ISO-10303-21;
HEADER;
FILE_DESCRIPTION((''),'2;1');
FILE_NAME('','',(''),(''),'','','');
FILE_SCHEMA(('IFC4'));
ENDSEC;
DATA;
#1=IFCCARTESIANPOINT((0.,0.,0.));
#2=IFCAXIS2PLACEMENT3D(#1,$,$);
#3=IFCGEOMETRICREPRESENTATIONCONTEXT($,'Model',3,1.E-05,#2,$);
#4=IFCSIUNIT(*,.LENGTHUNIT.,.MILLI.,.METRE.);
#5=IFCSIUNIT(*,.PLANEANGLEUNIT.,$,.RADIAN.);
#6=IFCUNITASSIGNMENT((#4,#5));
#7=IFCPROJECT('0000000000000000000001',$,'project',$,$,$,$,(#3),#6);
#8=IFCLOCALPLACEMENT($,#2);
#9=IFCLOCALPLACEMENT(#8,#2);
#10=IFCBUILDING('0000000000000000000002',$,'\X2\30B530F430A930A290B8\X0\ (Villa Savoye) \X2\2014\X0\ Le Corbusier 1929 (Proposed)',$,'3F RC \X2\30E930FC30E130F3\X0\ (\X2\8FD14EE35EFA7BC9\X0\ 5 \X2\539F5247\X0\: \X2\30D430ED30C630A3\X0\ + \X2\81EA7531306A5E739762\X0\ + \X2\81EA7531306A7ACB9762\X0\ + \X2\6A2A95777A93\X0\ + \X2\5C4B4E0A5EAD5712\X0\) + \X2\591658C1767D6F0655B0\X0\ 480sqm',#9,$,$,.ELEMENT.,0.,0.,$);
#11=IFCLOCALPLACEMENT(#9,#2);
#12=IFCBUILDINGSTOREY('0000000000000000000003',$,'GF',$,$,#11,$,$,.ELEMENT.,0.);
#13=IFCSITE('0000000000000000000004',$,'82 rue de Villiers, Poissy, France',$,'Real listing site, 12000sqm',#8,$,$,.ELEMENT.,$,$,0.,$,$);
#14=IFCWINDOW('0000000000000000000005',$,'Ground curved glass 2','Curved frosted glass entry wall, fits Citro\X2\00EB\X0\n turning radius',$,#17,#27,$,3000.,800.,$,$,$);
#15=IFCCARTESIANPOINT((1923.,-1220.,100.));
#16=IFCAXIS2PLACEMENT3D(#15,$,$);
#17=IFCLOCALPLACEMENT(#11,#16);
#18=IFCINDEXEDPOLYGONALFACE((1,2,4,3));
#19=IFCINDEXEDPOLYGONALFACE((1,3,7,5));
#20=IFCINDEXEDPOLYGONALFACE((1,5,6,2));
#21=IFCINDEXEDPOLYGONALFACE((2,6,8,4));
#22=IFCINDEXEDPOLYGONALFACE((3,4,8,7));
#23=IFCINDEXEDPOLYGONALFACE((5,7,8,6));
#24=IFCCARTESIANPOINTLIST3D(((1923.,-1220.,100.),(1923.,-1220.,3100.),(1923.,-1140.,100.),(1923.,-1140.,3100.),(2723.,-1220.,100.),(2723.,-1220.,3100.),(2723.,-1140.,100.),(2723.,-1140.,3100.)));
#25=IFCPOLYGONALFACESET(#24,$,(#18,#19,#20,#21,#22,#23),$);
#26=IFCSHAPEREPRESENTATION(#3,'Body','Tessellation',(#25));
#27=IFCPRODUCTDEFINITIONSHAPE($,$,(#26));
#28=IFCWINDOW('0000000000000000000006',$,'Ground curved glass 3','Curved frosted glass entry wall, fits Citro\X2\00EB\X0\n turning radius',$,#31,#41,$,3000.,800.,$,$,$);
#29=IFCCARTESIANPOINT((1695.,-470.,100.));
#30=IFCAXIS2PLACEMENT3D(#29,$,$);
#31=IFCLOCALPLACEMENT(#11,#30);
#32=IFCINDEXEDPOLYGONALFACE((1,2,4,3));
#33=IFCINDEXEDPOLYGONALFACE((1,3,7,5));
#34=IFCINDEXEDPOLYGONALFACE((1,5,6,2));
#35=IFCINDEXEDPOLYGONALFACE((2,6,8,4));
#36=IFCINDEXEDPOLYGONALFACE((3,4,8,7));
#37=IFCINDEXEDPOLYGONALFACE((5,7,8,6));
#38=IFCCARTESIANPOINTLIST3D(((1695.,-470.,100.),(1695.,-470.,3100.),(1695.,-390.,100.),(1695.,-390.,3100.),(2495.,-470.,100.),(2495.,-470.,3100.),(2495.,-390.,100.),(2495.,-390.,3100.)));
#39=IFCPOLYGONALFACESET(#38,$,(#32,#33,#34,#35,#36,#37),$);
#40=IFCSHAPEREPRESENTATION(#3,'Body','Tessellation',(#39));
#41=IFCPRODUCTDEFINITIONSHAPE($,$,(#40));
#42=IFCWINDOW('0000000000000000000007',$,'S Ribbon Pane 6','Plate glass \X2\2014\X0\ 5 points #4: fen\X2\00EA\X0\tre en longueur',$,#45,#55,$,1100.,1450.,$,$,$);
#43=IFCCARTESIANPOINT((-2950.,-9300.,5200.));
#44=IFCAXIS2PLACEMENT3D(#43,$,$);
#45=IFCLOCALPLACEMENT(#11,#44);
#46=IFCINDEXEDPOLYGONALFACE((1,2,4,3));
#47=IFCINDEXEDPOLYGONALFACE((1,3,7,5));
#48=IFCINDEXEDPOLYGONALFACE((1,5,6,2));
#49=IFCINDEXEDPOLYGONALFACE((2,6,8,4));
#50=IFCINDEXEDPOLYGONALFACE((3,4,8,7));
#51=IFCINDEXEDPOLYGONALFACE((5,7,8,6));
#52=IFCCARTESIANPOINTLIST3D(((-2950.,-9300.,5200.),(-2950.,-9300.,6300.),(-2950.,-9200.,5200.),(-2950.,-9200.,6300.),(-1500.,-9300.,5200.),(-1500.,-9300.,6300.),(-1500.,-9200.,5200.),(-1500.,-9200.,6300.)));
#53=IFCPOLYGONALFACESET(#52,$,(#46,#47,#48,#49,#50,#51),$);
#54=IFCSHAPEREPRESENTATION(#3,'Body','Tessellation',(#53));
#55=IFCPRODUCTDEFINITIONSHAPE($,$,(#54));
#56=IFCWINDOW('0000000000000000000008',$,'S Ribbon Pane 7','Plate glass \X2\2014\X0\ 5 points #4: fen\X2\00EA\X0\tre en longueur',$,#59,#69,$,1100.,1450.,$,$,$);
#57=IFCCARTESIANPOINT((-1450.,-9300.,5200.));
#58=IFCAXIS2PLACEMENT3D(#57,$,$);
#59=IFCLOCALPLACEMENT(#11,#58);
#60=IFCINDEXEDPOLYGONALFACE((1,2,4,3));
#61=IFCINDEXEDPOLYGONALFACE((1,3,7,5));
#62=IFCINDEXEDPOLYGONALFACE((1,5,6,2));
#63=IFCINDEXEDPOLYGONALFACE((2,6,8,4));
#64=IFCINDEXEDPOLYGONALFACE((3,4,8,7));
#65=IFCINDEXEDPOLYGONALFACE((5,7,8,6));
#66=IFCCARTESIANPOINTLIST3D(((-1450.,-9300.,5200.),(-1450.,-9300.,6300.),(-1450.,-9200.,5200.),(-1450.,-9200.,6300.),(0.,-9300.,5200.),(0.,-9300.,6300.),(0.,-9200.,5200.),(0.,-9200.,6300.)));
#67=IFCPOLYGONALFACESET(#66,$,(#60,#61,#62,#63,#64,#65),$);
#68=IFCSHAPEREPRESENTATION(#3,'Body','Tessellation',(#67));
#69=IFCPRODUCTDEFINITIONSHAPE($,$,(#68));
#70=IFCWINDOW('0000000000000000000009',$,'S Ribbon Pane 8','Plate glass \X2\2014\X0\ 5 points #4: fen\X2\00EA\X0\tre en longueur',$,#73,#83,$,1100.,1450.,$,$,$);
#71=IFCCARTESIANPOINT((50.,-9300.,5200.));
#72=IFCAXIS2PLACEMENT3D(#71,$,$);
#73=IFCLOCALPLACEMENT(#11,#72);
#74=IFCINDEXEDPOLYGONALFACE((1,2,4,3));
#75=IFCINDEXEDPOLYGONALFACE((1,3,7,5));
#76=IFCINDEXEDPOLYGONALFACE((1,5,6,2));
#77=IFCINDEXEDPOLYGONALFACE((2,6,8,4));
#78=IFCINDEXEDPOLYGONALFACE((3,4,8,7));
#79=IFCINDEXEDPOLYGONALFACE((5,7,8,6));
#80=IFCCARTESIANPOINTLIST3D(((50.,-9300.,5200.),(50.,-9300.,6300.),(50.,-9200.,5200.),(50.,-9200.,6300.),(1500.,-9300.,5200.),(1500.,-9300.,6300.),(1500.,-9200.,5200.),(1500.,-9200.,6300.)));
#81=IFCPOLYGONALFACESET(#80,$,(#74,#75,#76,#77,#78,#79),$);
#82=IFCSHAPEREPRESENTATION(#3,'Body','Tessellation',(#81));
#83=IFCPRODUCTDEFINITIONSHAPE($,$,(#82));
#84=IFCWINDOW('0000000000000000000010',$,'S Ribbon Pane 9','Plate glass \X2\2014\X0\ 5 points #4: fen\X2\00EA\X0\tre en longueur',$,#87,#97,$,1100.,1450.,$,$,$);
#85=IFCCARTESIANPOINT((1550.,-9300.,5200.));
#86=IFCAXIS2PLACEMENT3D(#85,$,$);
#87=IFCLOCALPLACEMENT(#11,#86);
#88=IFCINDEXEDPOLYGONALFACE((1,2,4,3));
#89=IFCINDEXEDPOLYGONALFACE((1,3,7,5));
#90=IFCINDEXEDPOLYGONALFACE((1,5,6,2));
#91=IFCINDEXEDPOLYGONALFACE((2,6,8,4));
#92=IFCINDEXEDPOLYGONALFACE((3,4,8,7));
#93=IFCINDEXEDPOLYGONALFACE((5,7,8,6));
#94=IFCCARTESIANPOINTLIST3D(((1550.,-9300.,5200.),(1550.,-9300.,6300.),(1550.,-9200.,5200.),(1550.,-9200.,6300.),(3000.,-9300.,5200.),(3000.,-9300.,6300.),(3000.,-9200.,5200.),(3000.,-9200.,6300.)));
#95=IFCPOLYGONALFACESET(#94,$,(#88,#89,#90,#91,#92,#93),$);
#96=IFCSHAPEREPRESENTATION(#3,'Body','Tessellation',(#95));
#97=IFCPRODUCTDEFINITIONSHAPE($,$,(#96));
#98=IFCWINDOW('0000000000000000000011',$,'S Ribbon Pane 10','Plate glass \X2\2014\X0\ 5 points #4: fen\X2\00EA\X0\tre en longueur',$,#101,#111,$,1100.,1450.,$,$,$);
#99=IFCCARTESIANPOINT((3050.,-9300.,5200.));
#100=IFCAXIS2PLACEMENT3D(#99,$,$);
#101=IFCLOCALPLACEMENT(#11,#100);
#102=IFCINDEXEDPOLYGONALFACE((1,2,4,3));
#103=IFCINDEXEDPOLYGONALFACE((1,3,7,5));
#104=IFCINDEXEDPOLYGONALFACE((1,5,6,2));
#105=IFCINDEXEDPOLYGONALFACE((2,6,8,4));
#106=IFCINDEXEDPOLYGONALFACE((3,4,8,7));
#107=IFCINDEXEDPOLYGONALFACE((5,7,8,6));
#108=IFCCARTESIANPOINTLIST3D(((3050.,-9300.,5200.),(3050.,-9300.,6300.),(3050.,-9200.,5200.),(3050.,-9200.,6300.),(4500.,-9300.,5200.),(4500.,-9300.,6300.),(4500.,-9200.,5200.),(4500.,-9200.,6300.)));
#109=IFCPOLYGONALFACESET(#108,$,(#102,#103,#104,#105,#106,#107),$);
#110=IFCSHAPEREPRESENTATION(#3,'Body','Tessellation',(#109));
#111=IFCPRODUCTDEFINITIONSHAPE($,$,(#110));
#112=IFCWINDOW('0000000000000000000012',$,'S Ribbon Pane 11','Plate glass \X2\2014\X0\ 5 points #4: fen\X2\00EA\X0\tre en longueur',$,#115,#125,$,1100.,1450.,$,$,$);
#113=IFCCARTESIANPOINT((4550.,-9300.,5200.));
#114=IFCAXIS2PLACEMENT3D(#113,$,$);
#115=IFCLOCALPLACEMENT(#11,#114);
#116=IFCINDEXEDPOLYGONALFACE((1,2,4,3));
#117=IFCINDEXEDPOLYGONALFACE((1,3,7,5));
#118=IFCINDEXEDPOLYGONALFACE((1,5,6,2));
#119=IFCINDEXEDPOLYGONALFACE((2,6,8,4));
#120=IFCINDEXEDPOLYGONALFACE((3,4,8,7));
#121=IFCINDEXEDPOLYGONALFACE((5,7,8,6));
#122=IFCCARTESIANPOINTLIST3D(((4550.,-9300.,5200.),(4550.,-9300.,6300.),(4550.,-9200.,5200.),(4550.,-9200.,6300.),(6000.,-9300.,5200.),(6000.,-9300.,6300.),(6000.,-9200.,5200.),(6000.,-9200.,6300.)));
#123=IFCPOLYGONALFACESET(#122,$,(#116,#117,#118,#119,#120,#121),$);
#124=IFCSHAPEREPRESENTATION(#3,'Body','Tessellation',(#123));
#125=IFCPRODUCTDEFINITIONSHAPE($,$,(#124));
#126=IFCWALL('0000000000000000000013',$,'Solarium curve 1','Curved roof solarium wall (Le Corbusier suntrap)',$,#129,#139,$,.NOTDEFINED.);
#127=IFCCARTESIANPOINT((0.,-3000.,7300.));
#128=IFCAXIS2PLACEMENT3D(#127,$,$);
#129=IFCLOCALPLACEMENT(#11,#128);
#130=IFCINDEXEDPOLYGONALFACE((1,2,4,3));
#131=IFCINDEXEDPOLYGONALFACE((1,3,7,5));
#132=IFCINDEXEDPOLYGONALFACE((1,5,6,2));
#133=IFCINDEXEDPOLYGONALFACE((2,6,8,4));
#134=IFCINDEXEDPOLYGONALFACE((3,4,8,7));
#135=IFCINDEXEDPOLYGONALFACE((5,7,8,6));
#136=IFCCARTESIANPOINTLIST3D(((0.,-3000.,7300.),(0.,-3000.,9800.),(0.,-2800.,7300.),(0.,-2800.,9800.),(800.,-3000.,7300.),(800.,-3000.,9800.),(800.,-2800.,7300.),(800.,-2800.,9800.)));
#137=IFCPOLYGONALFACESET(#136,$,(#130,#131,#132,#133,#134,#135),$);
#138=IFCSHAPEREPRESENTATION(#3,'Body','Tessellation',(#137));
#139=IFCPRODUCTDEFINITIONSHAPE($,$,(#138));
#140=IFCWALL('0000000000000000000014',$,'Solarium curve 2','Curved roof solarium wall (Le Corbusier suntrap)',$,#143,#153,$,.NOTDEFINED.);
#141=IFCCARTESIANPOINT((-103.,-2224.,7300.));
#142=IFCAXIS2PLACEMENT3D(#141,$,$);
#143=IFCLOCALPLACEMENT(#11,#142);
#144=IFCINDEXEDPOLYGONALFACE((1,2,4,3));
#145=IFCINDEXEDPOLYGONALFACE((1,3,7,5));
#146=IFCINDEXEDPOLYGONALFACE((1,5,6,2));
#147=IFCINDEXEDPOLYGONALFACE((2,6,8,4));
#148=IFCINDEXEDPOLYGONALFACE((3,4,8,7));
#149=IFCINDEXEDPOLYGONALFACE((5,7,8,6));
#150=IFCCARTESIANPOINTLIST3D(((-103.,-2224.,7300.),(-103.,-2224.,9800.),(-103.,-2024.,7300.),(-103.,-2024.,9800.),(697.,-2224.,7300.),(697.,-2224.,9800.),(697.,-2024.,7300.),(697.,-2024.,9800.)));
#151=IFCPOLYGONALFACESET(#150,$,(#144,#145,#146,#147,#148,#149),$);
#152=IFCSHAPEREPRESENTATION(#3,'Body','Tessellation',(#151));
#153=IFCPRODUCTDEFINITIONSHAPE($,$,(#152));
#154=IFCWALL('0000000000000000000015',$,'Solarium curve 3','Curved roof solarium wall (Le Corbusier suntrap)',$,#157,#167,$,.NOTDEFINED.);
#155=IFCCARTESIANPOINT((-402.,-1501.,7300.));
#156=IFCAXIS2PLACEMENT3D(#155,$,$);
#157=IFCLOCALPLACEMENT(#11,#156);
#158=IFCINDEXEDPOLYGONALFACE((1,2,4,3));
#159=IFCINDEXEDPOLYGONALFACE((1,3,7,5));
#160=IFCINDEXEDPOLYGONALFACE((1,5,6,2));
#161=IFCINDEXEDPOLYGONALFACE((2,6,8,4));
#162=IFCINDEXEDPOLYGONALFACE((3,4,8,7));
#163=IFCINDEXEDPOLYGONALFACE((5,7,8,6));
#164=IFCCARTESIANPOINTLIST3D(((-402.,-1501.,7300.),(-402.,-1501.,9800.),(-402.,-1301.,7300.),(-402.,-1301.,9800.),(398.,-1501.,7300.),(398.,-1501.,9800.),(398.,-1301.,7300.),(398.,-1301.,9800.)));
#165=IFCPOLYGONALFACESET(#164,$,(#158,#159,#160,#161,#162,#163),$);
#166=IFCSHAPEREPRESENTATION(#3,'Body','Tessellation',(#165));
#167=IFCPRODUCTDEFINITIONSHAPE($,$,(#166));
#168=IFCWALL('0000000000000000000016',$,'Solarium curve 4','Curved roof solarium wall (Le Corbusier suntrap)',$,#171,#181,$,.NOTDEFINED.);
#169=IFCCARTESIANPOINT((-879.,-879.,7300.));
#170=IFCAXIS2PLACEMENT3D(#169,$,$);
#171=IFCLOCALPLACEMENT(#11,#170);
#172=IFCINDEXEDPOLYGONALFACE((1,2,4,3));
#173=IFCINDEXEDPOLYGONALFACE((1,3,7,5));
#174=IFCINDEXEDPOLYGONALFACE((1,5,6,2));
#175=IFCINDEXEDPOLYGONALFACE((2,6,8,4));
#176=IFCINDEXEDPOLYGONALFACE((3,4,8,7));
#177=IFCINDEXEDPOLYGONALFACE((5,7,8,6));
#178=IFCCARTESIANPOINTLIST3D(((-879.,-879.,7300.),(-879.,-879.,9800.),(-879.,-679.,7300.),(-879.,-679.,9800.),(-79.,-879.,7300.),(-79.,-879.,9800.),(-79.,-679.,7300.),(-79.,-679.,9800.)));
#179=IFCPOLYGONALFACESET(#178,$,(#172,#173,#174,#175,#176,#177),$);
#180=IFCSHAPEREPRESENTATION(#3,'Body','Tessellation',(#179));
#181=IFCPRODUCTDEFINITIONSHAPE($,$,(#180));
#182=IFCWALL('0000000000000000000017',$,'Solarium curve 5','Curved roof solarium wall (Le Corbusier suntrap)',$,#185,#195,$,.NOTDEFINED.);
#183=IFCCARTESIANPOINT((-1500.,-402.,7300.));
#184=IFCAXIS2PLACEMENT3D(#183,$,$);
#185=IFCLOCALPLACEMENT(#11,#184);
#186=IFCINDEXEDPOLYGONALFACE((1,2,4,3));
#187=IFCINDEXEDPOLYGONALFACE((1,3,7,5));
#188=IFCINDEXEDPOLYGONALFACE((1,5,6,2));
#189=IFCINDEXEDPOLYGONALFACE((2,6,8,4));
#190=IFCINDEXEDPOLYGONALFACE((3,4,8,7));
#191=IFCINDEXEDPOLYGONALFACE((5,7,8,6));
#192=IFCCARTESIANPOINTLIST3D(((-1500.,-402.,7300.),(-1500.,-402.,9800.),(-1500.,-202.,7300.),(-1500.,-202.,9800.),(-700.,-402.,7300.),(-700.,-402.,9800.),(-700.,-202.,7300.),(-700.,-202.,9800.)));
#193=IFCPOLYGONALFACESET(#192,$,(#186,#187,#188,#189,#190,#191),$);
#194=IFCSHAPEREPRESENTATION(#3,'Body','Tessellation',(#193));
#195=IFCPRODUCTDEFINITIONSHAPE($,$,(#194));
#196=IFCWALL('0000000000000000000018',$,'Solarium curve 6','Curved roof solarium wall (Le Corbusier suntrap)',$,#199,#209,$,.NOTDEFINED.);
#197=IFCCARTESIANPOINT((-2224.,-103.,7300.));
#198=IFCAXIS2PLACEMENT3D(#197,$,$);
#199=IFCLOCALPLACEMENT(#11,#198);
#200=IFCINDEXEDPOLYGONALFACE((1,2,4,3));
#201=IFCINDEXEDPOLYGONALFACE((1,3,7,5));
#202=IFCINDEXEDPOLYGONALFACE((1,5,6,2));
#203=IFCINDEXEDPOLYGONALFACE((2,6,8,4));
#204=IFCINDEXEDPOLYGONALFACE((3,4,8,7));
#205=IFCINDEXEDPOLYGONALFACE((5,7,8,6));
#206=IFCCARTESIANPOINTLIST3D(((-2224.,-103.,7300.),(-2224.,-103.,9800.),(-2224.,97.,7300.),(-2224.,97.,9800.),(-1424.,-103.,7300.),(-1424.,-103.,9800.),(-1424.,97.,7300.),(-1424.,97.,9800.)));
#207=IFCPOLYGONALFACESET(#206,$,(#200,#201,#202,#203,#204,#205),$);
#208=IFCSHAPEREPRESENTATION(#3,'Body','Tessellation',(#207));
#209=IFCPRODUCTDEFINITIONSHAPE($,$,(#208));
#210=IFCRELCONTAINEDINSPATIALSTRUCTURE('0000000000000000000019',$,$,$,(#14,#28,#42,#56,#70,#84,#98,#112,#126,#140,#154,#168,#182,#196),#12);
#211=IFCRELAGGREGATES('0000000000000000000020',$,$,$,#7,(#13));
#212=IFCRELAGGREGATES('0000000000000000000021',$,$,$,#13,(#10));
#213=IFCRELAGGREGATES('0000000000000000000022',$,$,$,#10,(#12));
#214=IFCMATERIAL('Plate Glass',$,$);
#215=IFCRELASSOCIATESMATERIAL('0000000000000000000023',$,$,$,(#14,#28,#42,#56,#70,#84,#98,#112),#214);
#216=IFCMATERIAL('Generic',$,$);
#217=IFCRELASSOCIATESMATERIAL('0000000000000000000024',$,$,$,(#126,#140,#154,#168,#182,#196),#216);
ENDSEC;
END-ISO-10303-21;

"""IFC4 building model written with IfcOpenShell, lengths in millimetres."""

from ifc_helpers import new_model, si_unit, frame, frame_2d, origin, place, context, project, spatial, rectangle, extrude, material, element, save


model = new_model("IFC4")

# Units and contexts
model_context = context("Model", 3, precision=1e-05, world=origin())
ifc_project = project(units=[si_unit("LENGTHUNIT", "METRE", prefix="MILLI"), si_unit("PLANEANGLEUNIT", "RADIAN")], contexts=[model_context])

# Site, building, storey
site_placement = place(None, origin())
site = spatial("IfcSite", under=ifc_project, at=site_placement, Name="82 rue de Villiers, Poissy, France", ObjectType="Real listing site, 12000sqm", CompositionType="ELEMENT", RefElevation=0.0)
building_placement = place(site_placement, origin())
building = spatial("IfcBuilding", under=site, at=building_placement, Name="サヴォア邸 (Villa Savoye) — Le Corbusier 1929 (Proposed)", ObjectType="3F RC ラーメン (近代建築 5 原則: ピロティ + 自由な平面 + 自由な立面 + 横長窓 + 屋上庭園) + 外壁白漆喰 480sqm", CompositionType="ELEMENT", ElevationOfRefHeight=0.0, ElevationOfTerrain=0.0)
storey_placement = place(building_placement, origin())
storey = spatial("IfcBuildingStorey", under=building, at=storey_placement, Name="GF", CompositionType="ELEMENT", Elevation=0.0)

# Shared definitions
ifc_material_1 = material(Name="Generic")

# Windows
ifc_material_2 = material(Name="Plate Glass")
window_1_placement = place(storey_placement, frame((1923.0, -1220.0, 100.0)))
element("IfcWindow", 1, at=window_1_placement, inside=storey, material=ifc_material_2, Name="Ground curved glass 2", Description="Curved frosted glass entry wall, fits Citroën turning radius", OverallHeight=3000.0, OverallWidth=800.0, context=model_context, shape_type="SweptSolid", body=[
    extrude(rectangle(XDim=800.0, YDim=80.0, at=frame_2d((400.0, 40.0))), frame((1923.0, -1220.0, 100.0)), (0.0, 0.0, 1.0), 3000.0),
])
window_2_placement = place(storey_placement, frame((1695.0, -470.0, 100.0)))
element("IfcWindow", 2, at=window_2_placement, inside=storey, material=ifc_material_2, Name="Ground curved glass 3", Description="Curved frosted glass entry wall, fits Citroën turning radius", OverallHeight=3000.0, OverallWidth=800.0, context=model_context, shape_type="SweptSolid", body=[
    extrude(rectangle(XDim=800.0, YDim=80.0, at=frame_2d((400.0, 40.0))), frame((1695.0, -470.0, 100.0)), (0.0, 0.0, 1.0), 3000.0),
])
window_3_placement = place(storey_placement, frame((-2950.0, -9300.0, 5200.0)))
element("IfcWindow", 3, at=window_3_placement, inside=storey, material=ifc_material_2, Name="S Ribbon Pane 6", Description="Plate glass — 5 points #4: fenêtre en longueur", OverallHeight=1100.0, OverallWidth=1450.0, context=model_context, shape_type="SweptSolid", body=[
    extrude(rectangle(XDim=1450.0, YDim=100.0, at=frame_2d((725.0, 50.0))), frame((-2950.0, -9300.0, 5200.0)), (0.0, 0.0, 1.0), 1100.0),
])
window_4_placement = place(storey_placement, frame((-1450.0, -9300.0, 5200.0)))
element("IfcWindow", 4, at=window_4_placement, inside=storey, material=ifc_material_2, Name="S Ribbon Pane 7", Description="Plate glass — 5 points #4: fenêtre en longueur", OverallHeight=1100.0, OverallWidth=1450.0, context=model_context, shape_type="SweptSolid", body=[
    extrude(rectangle(XDim=1450.0, YDim=100.0, at=frame_2d((725.0, 50.0))), frame((-1450.0, -9300.0, 5200.0)), (0.0, 0.0, 1.0), 1100.0),
])
window_5_placement = place(storey_placement, frame((50.0, -9300.0, 5200.0)))
element("IfcWindow", 5, at=window_5_placement, inside=storey, material=ifc_material_2, Name="S Ribbon Pane 8", Description="Plate glass — 5 points #4: fenêtre en longueur", OverallHeight=1100.0, OverallWidth=1450.0, context=model_context, shape_type="SweptSolid", body=[
    extrude(rectangle(XDim=1450.0, YDim=100.0, at=frame_2d((725.0, 50.0))), frame((50.0, -9300.0, 5200.0)), (0.0, 0.0, 1.0), 1100.0),
])
window_6_placement = place(storey_placement, frame((1550.0, -9300.0, 5200.0)))
element("IfcWindow", 6, at=window_6_placement, inside=storey, material=ifc_material_2, Name="S Ribbon Pane 9", Description="Plate glass — 5 points #4: fenêtre en longueur", OverallHeight=1100.0, OverallWidth=1450.0, context=model_context, shape_type="SweptSolid", body=[
    extrude(rectangle(XDim=1450.0, YDim=100.0, at=frame_2d((725.0, 50.0))), frame((1550.0, -9300.0, 5200.0)), (0.0, 0.0, 1.0), 1100.0),
])
window_7_placement = place(storey_placement, frame((3050.0, -9300.0, 5200.0)))
element("IfcWindow", 7, at=window_7_placement, inside=storey, material=ifc_material_2, Name="S Ribbon Pane 10", Description="Plate glass — 5 points #4: fenêtre en longueur", OverallHeight=1100.0, OverallWidth=1450.0, context=model_context, shape_type="SweptSolid", body=[
    extrude(rectangle(XDim=1450.0, YDim=100.0, at=frame_2d((725.0, 50.0))), frame((3050.0, -9300.0, 5200.0)), (0.0, 0.0, 1.0), 1100.0),
])
window_8_placement = place(storey_placement, frame((4550.0, -9300.0, 5200.0)))
element("IfcWindow", 8, at=window_8_placement, inside=storey, material=ifc_material_2, Name="S Ribbon Pane 11", Description="Plate glass — 5 points #4: fenêtre en longueur", OverallHeight=1100.0, OverallWidth=1450.0, context=model_context, shape_type="SweptSolid", body=[
    extrude(rectangle(XDim=1450.0, YDim=100.0, at=frame_2d((725.0, 50.0))), frame((4550.0, -9300.0, 5200.0)), (0.0, 0.0, 1.0), 1100.0),
])

# Walls
wall_1_placement = place(storey_placement, frame((0.0, -3000.0, 7300.0)))
element("IfcWall", 9, at=wall_1_placement, inside=storey, material=ifc_material_1, Name="Solarium curve 1", Description="Curved roof solarium wall (Le Corbusier suntrap)", PredefinedType="NOTDEFINED", context=model_context, shape_type="SweptSolid", body=[
    extrude(rectangle(XDim=800.0, YDim=200.0, at=frame_2d((400.0, 100.0))), frame((0.0, -3000.0, 7300.0)), (0.0, 0.0, 1.0), 2500.0),
])
wall_2_placement = place(storey_placement, frame((-103.0, -2224.0, 7300.0)))
element("IfcWall", 10, at=wall_2_placement, inside=storey, material=ifc_material_1, Name="Solarium curve 2", Description="Curved roof solarium wall (Le Corbusier suntrap)", PredefinedType="NOTDEFINED", context=model_context, shape_type="SweptSolid", body=[
    extrude(rectangle(XDim=800.0, YDim=200.0, at=frame_2d((400.0, 100.0))), frame((-103.0, -2224.0, 7300.0)), (0.0, 0.0, 1.0), 2500.0),
])
wall_3_placement = place(storey_placement, frame((-402.0, -1501.0, 7300.0)))
element("IfcWall", 11, at=wall_3_placement, inside=storey, material=ifc_material_1, Name="Solarium curve 3", Description="Curved roof solarium wall (Le Corbusier suntrap)", PredefinedType="NOTDEFINED", context=model_context, shape_type="SweptSolid", body=[
    extrude(rectangle(XDim=800.0, YDim=200.0, at=frame_2d((400.0, 100.0))), frame((-402.0, -1501.0, 7300.0)), (0.0, 0.0, 1.0), 2500.0),
])
wall_4_placement = place(storey_placement, frame((-879.0, -879.0, 7300.0)))
element("IfcWall", 12, at=wall_4_placement, inside=storey, material=ifc_material_1, Name="Solarium curve 4", Description="Curved roof solarium wall (Le Corbusier suntrap)", PredefinedType="NOTDEFINED", context=model_context, shape_type="SweptSolid", body=[
    extrude(rectangle(XDim=800.0, YDim=200.0, at=frame_2d((400.0, 100.0))), frame((-879.0, -879.0, 7300.0)), (0.0, 0.0, 1.0), 2500.0),
])
wall_5_placement = place(storey_placement, frame((-1500.0, -402.0, 7300.0)))
element("IfcWall", 13, at=wall_5_placement, inside=storey, material=ifc_material_1, Name="Solarium curve 5", Description="Curved roof solarium wall (Le Corbusier suntrap)", PredefinedType="NOTDEFINED", context=model_context, shape_type="SweptSolid", body=[
    extrude(rectangle(XDim=800.0, YDim=200.0, at=frame_2d((400.0, 100.0))), frame((-1500.0, -402.0, 7300.0)), (0.0, 0.0, 1.0), 2500.0),
])
wall_6_placement = place(storey_placement, frame((-2224.0, -103.0, 7300.0)))
element("IfcWall", 14, at=wall_6_placement, inside=storey, material=ifc_material_1, Name="Solarium curve 6", Description="Curved roof solarium wall (Le Corbusier suntrap)", PredefinedType="NOTDEFINED", context=model_context, shape_type="SweptSolid", body=[
    extrude(rectangle(XDim=800.0, YDim=200.0, at=frame_2d((400.0, 100.0))), frame((-2224.0, -103.0, 7300.0)), (0.0, 0.0, 1.0), 2500.0),
])

save(model, "model.ifc")
